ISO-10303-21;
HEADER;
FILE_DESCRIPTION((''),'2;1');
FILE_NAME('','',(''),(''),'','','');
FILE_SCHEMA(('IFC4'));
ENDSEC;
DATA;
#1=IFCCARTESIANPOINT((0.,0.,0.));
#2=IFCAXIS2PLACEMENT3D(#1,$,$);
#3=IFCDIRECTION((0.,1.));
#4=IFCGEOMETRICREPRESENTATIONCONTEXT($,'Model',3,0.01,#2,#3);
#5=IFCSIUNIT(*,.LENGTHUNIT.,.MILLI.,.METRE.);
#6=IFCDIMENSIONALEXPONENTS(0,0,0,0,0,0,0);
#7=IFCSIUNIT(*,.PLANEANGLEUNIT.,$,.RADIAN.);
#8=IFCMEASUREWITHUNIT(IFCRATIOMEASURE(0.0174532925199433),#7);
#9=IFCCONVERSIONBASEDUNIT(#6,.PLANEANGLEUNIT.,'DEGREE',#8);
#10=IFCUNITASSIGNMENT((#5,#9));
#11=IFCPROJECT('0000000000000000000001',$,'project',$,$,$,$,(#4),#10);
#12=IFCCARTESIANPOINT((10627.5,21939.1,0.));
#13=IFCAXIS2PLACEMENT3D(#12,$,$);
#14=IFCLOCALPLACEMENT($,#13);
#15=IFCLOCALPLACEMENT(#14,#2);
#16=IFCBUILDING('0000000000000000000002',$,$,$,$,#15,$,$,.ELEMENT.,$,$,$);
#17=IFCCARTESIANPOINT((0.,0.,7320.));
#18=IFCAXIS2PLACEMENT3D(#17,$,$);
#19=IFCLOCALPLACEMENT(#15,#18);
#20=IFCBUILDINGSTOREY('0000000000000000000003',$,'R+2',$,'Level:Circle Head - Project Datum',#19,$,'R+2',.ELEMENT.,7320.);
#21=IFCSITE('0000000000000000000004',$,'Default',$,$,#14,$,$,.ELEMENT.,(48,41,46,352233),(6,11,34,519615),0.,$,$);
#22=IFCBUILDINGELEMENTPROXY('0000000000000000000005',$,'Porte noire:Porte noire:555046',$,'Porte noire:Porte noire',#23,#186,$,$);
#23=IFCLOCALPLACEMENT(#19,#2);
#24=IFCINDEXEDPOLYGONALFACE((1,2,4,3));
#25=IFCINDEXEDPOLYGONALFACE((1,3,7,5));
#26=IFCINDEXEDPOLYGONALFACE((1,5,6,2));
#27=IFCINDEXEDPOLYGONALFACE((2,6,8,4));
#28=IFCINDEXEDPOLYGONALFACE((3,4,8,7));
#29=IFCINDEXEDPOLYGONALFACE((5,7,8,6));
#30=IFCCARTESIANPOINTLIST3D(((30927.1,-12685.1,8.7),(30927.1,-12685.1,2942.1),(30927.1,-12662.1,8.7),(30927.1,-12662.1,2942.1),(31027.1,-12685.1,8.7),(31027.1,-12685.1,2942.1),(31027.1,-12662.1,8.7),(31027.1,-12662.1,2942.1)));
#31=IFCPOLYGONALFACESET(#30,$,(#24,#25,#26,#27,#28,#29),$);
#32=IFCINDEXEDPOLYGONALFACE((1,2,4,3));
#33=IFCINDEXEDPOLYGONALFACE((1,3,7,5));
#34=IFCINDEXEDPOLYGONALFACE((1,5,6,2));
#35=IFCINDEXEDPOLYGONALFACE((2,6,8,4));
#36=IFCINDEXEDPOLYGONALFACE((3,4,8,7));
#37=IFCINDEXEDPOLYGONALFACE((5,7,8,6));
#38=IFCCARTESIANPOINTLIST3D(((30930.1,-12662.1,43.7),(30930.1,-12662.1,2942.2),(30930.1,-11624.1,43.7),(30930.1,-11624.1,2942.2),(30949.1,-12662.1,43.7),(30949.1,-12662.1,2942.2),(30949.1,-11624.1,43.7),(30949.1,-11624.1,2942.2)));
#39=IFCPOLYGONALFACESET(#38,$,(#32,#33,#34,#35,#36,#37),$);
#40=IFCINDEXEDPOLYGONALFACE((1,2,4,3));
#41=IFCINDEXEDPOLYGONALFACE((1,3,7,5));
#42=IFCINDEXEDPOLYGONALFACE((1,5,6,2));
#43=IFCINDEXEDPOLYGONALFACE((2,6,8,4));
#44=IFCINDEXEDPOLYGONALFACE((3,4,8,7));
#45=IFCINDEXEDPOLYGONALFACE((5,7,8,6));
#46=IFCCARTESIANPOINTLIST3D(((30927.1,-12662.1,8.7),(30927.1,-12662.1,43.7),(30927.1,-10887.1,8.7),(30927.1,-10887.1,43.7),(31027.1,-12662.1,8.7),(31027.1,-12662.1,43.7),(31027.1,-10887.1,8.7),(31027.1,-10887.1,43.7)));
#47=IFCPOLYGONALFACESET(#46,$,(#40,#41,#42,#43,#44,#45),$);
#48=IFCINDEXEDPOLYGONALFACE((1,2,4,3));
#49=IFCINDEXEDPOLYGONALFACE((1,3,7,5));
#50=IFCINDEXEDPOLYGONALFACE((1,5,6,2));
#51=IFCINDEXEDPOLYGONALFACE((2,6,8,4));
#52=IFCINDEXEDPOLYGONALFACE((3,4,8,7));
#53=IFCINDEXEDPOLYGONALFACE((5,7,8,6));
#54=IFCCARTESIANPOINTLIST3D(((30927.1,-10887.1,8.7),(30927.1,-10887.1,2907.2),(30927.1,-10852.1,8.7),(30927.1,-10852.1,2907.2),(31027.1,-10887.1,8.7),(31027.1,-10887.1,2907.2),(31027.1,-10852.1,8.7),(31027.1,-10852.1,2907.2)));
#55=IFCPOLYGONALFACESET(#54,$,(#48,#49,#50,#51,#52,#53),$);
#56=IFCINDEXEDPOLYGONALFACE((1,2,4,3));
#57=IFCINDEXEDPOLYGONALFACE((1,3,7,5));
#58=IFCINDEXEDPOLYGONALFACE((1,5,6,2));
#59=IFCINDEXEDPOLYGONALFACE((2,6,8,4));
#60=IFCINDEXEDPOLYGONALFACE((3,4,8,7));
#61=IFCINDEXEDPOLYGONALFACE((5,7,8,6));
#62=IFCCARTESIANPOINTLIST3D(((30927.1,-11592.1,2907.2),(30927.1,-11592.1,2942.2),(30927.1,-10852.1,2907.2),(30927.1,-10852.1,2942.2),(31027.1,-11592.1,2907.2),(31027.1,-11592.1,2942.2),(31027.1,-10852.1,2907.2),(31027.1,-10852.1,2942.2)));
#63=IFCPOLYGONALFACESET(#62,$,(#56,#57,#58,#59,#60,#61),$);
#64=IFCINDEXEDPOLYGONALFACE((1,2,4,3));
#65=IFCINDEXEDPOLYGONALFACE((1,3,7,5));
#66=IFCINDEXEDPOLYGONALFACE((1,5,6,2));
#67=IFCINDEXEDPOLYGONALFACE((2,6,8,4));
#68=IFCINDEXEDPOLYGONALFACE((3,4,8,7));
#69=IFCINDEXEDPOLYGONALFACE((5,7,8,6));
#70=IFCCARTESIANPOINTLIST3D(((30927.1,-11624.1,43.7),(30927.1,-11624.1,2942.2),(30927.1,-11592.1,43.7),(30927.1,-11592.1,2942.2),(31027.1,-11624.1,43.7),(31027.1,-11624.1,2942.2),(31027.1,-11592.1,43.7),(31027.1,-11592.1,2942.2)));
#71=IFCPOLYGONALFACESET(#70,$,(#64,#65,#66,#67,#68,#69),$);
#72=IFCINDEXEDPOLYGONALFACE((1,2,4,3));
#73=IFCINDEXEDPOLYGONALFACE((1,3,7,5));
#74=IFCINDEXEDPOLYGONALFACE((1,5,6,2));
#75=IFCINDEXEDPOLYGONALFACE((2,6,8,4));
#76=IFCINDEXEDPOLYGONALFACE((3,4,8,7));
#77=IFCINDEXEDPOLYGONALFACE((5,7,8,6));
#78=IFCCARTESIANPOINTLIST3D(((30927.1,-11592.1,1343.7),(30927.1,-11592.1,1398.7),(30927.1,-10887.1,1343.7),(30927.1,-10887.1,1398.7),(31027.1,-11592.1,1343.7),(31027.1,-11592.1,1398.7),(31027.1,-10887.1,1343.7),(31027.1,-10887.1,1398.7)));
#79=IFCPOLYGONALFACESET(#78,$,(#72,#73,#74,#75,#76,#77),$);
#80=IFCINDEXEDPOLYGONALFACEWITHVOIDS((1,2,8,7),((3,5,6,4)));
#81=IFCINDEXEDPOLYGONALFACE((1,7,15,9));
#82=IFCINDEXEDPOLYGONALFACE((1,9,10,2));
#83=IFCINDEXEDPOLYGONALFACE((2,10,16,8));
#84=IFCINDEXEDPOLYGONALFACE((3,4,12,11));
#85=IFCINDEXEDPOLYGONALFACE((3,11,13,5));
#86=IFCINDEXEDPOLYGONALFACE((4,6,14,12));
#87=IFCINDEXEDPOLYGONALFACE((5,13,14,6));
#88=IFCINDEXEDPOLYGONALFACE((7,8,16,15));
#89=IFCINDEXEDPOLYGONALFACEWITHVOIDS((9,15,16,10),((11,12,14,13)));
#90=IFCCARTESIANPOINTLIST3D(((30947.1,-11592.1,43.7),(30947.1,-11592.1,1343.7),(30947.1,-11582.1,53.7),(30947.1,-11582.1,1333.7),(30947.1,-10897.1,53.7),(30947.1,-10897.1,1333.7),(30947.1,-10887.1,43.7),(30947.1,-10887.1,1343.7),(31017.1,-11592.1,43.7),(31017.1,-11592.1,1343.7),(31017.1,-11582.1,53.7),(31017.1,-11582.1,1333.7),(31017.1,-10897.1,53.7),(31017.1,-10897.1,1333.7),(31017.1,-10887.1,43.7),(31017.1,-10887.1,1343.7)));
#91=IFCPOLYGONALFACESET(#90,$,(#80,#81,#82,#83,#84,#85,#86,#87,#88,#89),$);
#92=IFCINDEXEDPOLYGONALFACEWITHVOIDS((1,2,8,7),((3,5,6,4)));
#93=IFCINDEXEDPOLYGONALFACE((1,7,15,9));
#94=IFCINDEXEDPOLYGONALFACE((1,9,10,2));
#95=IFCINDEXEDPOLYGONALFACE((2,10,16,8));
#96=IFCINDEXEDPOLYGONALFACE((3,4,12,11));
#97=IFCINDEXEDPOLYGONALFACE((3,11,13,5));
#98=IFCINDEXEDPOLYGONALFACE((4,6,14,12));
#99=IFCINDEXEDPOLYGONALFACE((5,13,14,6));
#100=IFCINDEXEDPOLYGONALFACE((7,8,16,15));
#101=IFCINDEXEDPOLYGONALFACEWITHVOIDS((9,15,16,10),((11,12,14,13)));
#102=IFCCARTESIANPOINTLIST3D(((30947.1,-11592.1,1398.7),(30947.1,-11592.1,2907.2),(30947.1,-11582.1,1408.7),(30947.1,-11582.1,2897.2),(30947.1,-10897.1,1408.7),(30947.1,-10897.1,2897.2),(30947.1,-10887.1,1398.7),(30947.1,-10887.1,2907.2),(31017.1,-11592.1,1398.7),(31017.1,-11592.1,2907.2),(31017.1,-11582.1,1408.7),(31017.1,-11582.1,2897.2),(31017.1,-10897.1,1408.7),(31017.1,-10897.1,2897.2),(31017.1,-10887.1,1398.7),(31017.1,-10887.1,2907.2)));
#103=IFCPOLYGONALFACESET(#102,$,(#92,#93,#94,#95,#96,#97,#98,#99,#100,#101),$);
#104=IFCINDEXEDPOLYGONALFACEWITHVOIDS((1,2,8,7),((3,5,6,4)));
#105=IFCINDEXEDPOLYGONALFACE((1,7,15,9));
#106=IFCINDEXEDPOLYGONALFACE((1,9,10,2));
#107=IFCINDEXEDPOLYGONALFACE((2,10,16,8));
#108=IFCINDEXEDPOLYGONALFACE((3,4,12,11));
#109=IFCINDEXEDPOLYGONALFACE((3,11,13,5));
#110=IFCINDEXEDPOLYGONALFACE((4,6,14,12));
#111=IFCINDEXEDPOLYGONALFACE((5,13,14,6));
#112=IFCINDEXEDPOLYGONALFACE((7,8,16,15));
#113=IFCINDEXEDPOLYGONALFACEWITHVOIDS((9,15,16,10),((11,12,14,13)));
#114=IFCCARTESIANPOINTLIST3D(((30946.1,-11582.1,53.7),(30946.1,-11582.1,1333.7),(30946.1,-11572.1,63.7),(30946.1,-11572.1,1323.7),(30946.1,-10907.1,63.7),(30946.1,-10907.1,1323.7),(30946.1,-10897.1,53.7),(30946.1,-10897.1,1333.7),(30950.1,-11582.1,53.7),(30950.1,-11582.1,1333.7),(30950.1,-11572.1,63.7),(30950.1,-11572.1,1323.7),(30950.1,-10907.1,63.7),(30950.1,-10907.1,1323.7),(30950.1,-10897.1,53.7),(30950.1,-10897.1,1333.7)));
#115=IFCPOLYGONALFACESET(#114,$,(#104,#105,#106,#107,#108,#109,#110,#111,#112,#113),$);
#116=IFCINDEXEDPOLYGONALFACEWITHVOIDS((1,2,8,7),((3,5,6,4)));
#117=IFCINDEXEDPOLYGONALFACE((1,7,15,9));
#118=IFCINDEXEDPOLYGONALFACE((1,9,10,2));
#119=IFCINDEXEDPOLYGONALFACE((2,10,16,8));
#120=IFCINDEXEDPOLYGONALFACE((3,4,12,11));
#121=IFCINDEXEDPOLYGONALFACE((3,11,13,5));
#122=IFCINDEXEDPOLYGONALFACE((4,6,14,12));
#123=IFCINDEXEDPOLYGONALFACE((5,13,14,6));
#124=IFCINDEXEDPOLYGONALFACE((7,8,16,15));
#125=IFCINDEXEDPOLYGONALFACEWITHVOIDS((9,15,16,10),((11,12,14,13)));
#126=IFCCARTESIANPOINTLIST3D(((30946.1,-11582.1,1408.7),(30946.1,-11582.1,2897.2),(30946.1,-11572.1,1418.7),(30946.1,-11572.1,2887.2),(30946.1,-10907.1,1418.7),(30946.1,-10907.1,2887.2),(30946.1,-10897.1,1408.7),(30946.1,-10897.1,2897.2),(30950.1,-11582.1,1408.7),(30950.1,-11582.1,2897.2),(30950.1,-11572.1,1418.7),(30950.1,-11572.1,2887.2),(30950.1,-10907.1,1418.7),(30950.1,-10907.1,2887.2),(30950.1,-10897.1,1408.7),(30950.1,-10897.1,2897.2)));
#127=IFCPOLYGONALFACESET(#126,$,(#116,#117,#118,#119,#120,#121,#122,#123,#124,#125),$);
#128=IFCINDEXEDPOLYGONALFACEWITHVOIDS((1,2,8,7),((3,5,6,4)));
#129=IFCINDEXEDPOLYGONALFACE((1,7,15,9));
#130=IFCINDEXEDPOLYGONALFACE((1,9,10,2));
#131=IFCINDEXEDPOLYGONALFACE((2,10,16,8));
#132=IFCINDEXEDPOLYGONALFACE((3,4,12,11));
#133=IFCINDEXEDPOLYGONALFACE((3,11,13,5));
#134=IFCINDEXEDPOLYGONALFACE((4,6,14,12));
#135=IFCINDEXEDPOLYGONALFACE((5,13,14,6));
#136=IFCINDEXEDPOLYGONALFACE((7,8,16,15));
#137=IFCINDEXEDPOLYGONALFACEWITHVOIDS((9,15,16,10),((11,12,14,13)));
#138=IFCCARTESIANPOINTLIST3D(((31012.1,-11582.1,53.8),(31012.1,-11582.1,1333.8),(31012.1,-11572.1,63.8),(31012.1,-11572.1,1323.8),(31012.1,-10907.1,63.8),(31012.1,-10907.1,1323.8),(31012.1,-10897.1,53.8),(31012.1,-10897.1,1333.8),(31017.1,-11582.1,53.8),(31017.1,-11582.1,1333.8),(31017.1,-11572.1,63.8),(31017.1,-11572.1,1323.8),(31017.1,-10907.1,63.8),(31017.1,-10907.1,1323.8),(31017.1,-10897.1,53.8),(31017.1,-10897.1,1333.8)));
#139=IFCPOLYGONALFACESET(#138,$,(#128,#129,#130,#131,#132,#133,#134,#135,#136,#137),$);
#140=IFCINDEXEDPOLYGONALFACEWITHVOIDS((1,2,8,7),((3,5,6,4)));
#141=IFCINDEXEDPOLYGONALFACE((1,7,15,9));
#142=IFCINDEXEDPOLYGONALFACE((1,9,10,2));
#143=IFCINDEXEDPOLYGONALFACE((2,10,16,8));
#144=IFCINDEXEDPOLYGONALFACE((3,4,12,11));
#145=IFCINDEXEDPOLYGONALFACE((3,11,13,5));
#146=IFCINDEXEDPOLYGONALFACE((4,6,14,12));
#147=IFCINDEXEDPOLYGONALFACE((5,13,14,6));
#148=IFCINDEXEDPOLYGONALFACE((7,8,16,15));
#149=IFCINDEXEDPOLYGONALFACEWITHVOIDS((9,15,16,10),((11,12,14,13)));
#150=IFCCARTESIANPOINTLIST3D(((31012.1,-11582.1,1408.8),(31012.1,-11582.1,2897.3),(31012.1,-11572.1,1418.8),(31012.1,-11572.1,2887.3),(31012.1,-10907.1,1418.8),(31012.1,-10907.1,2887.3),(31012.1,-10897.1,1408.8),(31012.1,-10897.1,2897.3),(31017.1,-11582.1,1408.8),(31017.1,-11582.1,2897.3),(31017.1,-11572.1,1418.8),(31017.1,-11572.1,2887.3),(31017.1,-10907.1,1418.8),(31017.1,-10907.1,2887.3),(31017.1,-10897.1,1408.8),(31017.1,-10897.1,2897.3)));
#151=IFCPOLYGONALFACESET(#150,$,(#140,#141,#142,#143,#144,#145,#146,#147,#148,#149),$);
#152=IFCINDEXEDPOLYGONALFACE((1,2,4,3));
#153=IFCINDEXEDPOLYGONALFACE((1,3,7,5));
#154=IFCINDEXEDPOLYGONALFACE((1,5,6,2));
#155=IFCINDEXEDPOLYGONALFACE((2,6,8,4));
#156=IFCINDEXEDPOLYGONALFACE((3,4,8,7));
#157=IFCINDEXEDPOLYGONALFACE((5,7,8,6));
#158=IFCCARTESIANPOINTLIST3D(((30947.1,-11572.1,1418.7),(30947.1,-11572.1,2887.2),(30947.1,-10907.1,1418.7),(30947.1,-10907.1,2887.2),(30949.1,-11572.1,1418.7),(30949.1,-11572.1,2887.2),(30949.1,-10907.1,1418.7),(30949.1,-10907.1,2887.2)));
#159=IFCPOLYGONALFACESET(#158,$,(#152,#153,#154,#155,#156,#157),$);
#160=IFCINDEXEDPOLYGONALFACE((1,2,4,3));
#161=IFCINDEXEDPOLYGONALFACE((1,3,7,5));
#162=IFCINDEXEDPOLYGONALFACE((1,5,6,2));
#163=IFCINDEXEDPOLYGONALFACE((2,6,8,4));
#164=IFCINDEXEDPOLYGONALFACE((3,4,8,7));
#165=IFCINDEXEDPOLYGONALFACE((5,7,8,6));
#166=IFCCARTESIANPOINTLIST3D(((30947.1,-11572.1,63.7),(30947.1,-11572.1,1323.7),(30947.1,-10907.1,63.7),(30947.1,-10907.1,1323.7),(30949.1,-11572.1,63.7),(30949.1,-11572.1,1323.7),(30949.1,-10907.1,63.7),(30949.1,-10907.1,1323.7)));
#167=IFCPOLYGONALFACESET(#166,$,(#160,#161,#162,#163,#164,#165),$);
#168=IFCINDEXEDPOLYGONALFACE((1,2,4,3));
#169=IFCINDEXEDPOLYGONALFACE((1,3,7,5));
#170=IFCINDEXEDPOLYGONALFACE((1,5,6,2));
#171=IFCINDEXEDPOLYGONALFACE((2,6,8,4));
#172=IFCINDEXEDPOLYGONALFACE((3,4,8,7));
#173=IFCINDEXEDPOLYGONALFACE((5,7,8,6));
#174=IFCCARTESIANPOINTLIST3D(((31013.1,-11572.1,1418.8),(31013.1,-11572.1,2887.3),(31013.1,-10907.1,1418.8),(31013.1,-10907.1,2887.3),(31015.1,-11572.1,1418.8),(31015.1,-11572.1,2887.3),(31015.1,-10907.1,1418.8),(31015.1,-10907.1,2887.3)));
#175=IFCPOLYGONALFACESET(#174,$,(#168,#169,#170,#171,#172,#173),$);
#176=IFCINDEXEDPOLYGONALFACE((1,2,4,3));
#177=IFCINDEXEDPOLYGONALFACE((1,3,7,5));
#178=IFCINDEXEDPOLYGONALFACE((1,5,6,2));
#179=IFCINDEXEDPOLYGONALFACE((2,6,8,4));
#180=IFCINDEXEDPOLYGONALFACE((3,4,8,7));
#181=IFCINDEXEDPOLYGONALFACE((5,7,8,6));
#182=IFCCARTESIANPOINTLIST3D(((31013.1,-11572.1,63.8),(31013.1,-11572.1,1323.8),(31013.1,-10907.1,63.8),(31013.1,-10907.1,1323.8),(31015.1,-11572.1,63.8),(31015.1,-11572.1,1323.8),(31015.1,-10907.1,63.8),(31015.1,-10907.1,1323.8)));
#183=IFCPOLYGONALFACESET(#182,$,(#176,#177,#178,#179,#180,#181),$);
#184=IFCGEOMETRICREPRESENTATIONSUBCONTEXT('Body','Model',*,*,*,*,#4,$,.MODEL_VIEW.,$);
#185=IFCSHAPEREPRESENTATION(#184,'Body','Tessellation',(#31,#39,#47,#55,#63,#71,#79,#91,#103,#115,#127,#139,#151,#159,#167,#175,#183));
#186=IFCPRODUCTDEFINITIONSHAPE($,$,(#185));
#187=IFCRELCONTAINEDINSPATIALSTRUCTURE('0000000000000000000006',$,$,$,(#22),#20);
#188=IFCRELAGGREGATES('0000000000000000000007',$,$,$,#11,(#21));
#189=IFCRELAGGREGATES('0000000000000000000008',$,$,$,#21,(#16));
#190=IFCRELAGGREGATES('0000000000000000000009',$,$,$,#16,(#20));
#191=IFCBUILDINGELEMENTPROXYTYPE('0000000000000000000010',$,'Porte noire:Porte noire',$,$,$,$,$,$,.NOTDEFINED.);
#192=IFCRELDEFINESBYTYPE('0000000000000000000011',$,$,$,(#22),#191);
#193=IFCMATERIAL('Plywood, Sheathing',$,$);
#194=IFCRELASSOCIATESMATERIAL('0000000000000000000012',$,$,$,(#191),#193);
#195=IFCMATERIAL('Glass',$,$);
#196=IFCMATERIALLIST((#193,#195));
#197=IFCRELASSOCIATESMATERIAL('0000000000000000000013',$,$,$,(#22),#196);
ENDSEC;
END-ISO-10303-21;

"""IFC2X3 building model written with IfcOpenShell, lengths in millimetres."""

from ifc_helpers import new_model, entity, si_unit, converted_unit, direction, frame, frame_2d, origin, origin_2d_with_axis, place, context, subcontext, project, spatial, polyline, rectangle, outline, extrude, source, transform, mapped, material, material_list, type_object, type_shapes, element, save


model = new_model("IFC2X3")

# Units and contexts
model_context = context("Model", 3, precision=0.01, world=origin(), true_north=direction((0.0, 1.0)))
body_context = subcontext(model_context, "Body", "Model", "MODEL_VIEW")
ifc_project = project(units=[si_unit("LENGTHUNIT", "METRE", prefix="MILLI"), converted_unit("PLANEANGLEUNIT", "DEGREE", entity("IfcRatioMeasure", 0.0174532925199433), si_unit("PLANEANGLEUNIT", "RADIAN"), dimensions=[0, 0, 0, 0, 0, 0, 0])], contexts=[model_context])

# Site, building, storey
site_placement = place(None, frame((10627.5, 21939.1, 0.0)))
site = spatial("IfcSite", under=ifc_project, at=site_placement, Name="Default", CompositionType="ELEMENT", RefLatitude=(48, 41, 46, 352233), RefLongitude=(6, 11, 34, 519615), RefElevation=0.0)
building_placement = place(site_placement, origin())
building = spatial("IfcBuilding", under=site, at=building_placement, CompositionType="ELEMENT")
storey_placement = place(building_placement, frame((0.0, 0.0, 7320.0)))
storey = spatial("IfcBuildingStorey", under=building, at=storey_placement, Name="R+2", ObjectType="Level:Circle Head - Project Datum", LongName="R+2", CompositionType="ELEMENT", Elevation=7320.0)

# Building element proxy
ifc_material_1 = material(Name="Plywood, Sheathing")
ifc_material_2 = material(Name="Glass")
building_element_proxy_type_1 = type_object("IfcBuildingElementProxyType", Name="Porte noire:Porte noire", PredefinedType="NOTDEFINED", material=ifc_material_1)
shared_shape_1 = source(origin(), body_context, "Body", "SweptSolid", [
    extrude(rectangle(XDim=23.0, YDim=100.0, at=frame_2d((0.0, 0.0), x_axis=(1.0, 0.0))), frame((-950.9, 50.0, 8.7), z_axis=(0.0, 0.0, 1.0), x_axis=(-1.0, 0.0, 0.0)), (0.0, 0.0, 1.0), 2933.3),
    extrude(rectangle(XDim=1038.0, YDim=19.0, at=frame_2d((0.0, 0.0), x_axis=(1.0, 0.0))), frame((-420.4, 87.5, 43.7), z_axis=(0.0, 0.0, 1.0), x_axis=(-1.0, 0.0, 0.0)), (0.0, 0.0, 1.0), 2898.5),
    extrude(rectangle(XDim=1775.0, YDim=100.0, at=origin_2d_with_axis()), frame((-51.9, 50.0, 8.7), z_axis=(0.0, 0.0, 1.0), x_axis=(-1.0, 0.0, 0.0)), (0.0, 0.0, 1.0), 35.0),
    extrude(rectangle(XDim=35.0, YDim=100.0, at=origin_2d_with_axis()), frame((853.1, 50.0, 8.7), z_axis=(0.0, 0.0, 1.0), x_axis=(-1.0, 0.0, 0.0)), (0.0, 0.0, 1.0), 2898.5),
    extrude(rectangle(XDim=740.0, YDim=100.0, at=origin_2d_with_axis()), frame((500.6, 50.0, 2907.2), z_axis=(0.0, 0.0, 1.0), x_axis=(-1.0, 0.0, 0.0)), (0.0, 0.0, 1.0), 35.0),
    extrude(rectangle(XDim=32.0, YDim=100.0, at=origin_2d_with_axis()), frame((114.6, 50.0, 43.7), z_axis=(0.0, 0.0, 1.0), x_axis=(-1.0, 0.0, 0.0)), (0.0, 0.0, 1.0), 2898.5),
    extrude(rectangle(XDim=705.0, YDim=100.0, at=origin_2d_with_axis()), frame((483.1, 50.0, 1343.7), z_axis=(0.0, 0.0, 1.0), x_axis=(-1.0, 0.0, 0.0)), (0.0, 0.0, 1.0), 55.0),
    extrude(outline(polyline([(-352.5, -650.0), (352.5, -650.0), (352.5, 650.0), (-352.5, 650.0), (-352.5, -650.0)]), holes=[polyline([(342.5, 640.0), (342.5, -640.0), (-342.5, -640.0), (-342.5, 640.0), (342.5, 640.0)])]), frame((483.1, 10.0, 693.7), z_axis=(0.0, 1.0, 0.0), x_axis=(1.0, 0.0, 0.0)), (0.0, 0.0, 1.0), 70.0),
    extrude(outline(polyline([(-754.2, -352.5), (754.2, -352.5), (754.2, 352.5), (-754.2, 352.5), (-754.2, -352.5)]), holes=[polyline([(744.2, 342.5), (744.2, -342.5), (-744.2, -342.5), (-744.2, 342.5), (744.2, 342.5)])]), frame((483.1, 10.0, 2153.0), z_axis=(0.0, 1.0, 0.0), x_axis=(0.0, 0.0, 1.0)), (0.0, 0.0, 1.0), 70.0),
    extrude(outline(polyline([(-640.0, -342.5), (640.0, -342.5), (640.0, 342.5), (-640.0, 342.5), (-640.0, -342.5)]), holes=[polyline([(630.0, 332.5), (630.0, -332.5), (-630.0, -332.5), (-630.0, 332.5), (630.0, 332.5)])]), frame((483.1, 77.0, 693.7), z_axis=(0.0, 1.0, 0.0), x_axis=(0.0, 0.0, 1.0)), (0.0, 0.0, 1.0), 4.0),
    extrude(outline(polyline([(-744.2, -342.5), (744.2, -342.5), (744.2, 342.5), (-744.2, 342.5), (-744.2, -342.5)]), holes=[polyline([(734.2, 332.5), (734.2, -332.5), (-734.2, -332.5), (-734.2, 332.5), (734.2, 332.5)])]), frame((483.1, 77.0, 2153.0), z_axis=(0.0, 1.0, 0.0), x_axis=(0.0, 0.0, 1.0)), (0.0, 0.0, 1.0), 4.0),
    extrude(outline(polyline([(-640.0, -342.5), (640.0, -342.5), (640.0, 342.5), (-640.0, 342.5), (-640.0, -342.5)]), holes=[polyline([(630.0, 332.5), (630.0, -332.5), (-630.0, -332.5), (-630.0, 332.5), (630.0, 332.5)])]), frame((483.1, 10.0, 693.8), z_axis=(0.0, 1.0, 0.0), x_axis=(0.0, 0.0, 1.0)), (0.0, 0.0, 1.0), 5.0),
    extrude(outline(polyline([(-744.2, -342.5), (744.2, -342.5), (744.2, 342.5), (-744.2, 342.5), (-744.2, -342.5)]), holes=[polyline([(734.2, 332.5), (734.2, -332.5), (-734.2, -332.5), (-734.2, 332.5), (734.2, 332.5)])]), frame((483.1, 10.0, 2153.0), z_axis=(0.0, 1.0, 0.0), x_axis=(0.0, 0.0, 1.0)), (0.0, 0.0, 1.0), 5.0),
    extrude(rectangle(XDim=665.0, YDim=2.0, at=frame_2d((0.0, 0.0), x_axis=(1.0, 0.0))), frame((483.1, 79.0, 1418.7), z_axis=(0.0, 0.0, 1.0), x_axis=(-1.0, 0.0, 0.0)), (0.0, 0.0, 1.0), 1468.5),
    extrude(rectangle(XDim=665.0, YDim=2.0, at=frame_2d((0.0, 0.0), x_axis=(1.0, 0.0))), frame((483.1, 79.0, 63.7), z_axis=(0.0, 0.0, 1.0), x_axis=(-1.0, 0.0, 0.0)), (0.0, 0.0, 1.0), 1260.0),
    extrude(rectangle(XDim=665.0, YDim=2.0, at=frame_2d((0.0, 0.0), x_axis=(1.0, 0.0))), frame((483.1, 13.0, 1418.8), z_axis=(0.0, 0.0, 1.0), x_axis=(-1.0, 0.0, 0.0)), (0.0, 0.0, 1.0), 1468.5),
    extrude(rectangle(XDim=665.0, YDim=2.0, at=frame_2d((0.0, 0.0), x_axis=(1.0, 0.0))), frame((483.1, 13.0, 63.8), z_axis=(0.0, 0.0, 1.0), x_axis=(-1.0, 0.0, 0.0)), (0.0, 0.0, 1.0), 1260.0),
])
type_shapes(building_element_proxy_type_1, [shared_shape_1])
ifc_material_list_1 = material_list([ifc_material_1, ifc_material_2])
proxy_1_placement = place(storey_placement, frame((31027.1, -11722.7, 0.0), z_axis=(0.0, 0.0, 1.0), x_axis=(0.0, 1.0, 0.0)))
element("IfcBuildingElementProxy", 1, at=proxy_1_placement, inside=storey, type_object=building_element_proxy_type_1, material=ifc_material_list_1, Name="Porte noire:Porte noire:555046", ObjectType="Porte noire:Porte noire", context=body_context, shape_type="MappedRepresentation", body=[
    mapped(shared_shape_1, transform((0.0, 0.0, 0.0), scale=1.0)),
])

save(model, "model.ifc")
